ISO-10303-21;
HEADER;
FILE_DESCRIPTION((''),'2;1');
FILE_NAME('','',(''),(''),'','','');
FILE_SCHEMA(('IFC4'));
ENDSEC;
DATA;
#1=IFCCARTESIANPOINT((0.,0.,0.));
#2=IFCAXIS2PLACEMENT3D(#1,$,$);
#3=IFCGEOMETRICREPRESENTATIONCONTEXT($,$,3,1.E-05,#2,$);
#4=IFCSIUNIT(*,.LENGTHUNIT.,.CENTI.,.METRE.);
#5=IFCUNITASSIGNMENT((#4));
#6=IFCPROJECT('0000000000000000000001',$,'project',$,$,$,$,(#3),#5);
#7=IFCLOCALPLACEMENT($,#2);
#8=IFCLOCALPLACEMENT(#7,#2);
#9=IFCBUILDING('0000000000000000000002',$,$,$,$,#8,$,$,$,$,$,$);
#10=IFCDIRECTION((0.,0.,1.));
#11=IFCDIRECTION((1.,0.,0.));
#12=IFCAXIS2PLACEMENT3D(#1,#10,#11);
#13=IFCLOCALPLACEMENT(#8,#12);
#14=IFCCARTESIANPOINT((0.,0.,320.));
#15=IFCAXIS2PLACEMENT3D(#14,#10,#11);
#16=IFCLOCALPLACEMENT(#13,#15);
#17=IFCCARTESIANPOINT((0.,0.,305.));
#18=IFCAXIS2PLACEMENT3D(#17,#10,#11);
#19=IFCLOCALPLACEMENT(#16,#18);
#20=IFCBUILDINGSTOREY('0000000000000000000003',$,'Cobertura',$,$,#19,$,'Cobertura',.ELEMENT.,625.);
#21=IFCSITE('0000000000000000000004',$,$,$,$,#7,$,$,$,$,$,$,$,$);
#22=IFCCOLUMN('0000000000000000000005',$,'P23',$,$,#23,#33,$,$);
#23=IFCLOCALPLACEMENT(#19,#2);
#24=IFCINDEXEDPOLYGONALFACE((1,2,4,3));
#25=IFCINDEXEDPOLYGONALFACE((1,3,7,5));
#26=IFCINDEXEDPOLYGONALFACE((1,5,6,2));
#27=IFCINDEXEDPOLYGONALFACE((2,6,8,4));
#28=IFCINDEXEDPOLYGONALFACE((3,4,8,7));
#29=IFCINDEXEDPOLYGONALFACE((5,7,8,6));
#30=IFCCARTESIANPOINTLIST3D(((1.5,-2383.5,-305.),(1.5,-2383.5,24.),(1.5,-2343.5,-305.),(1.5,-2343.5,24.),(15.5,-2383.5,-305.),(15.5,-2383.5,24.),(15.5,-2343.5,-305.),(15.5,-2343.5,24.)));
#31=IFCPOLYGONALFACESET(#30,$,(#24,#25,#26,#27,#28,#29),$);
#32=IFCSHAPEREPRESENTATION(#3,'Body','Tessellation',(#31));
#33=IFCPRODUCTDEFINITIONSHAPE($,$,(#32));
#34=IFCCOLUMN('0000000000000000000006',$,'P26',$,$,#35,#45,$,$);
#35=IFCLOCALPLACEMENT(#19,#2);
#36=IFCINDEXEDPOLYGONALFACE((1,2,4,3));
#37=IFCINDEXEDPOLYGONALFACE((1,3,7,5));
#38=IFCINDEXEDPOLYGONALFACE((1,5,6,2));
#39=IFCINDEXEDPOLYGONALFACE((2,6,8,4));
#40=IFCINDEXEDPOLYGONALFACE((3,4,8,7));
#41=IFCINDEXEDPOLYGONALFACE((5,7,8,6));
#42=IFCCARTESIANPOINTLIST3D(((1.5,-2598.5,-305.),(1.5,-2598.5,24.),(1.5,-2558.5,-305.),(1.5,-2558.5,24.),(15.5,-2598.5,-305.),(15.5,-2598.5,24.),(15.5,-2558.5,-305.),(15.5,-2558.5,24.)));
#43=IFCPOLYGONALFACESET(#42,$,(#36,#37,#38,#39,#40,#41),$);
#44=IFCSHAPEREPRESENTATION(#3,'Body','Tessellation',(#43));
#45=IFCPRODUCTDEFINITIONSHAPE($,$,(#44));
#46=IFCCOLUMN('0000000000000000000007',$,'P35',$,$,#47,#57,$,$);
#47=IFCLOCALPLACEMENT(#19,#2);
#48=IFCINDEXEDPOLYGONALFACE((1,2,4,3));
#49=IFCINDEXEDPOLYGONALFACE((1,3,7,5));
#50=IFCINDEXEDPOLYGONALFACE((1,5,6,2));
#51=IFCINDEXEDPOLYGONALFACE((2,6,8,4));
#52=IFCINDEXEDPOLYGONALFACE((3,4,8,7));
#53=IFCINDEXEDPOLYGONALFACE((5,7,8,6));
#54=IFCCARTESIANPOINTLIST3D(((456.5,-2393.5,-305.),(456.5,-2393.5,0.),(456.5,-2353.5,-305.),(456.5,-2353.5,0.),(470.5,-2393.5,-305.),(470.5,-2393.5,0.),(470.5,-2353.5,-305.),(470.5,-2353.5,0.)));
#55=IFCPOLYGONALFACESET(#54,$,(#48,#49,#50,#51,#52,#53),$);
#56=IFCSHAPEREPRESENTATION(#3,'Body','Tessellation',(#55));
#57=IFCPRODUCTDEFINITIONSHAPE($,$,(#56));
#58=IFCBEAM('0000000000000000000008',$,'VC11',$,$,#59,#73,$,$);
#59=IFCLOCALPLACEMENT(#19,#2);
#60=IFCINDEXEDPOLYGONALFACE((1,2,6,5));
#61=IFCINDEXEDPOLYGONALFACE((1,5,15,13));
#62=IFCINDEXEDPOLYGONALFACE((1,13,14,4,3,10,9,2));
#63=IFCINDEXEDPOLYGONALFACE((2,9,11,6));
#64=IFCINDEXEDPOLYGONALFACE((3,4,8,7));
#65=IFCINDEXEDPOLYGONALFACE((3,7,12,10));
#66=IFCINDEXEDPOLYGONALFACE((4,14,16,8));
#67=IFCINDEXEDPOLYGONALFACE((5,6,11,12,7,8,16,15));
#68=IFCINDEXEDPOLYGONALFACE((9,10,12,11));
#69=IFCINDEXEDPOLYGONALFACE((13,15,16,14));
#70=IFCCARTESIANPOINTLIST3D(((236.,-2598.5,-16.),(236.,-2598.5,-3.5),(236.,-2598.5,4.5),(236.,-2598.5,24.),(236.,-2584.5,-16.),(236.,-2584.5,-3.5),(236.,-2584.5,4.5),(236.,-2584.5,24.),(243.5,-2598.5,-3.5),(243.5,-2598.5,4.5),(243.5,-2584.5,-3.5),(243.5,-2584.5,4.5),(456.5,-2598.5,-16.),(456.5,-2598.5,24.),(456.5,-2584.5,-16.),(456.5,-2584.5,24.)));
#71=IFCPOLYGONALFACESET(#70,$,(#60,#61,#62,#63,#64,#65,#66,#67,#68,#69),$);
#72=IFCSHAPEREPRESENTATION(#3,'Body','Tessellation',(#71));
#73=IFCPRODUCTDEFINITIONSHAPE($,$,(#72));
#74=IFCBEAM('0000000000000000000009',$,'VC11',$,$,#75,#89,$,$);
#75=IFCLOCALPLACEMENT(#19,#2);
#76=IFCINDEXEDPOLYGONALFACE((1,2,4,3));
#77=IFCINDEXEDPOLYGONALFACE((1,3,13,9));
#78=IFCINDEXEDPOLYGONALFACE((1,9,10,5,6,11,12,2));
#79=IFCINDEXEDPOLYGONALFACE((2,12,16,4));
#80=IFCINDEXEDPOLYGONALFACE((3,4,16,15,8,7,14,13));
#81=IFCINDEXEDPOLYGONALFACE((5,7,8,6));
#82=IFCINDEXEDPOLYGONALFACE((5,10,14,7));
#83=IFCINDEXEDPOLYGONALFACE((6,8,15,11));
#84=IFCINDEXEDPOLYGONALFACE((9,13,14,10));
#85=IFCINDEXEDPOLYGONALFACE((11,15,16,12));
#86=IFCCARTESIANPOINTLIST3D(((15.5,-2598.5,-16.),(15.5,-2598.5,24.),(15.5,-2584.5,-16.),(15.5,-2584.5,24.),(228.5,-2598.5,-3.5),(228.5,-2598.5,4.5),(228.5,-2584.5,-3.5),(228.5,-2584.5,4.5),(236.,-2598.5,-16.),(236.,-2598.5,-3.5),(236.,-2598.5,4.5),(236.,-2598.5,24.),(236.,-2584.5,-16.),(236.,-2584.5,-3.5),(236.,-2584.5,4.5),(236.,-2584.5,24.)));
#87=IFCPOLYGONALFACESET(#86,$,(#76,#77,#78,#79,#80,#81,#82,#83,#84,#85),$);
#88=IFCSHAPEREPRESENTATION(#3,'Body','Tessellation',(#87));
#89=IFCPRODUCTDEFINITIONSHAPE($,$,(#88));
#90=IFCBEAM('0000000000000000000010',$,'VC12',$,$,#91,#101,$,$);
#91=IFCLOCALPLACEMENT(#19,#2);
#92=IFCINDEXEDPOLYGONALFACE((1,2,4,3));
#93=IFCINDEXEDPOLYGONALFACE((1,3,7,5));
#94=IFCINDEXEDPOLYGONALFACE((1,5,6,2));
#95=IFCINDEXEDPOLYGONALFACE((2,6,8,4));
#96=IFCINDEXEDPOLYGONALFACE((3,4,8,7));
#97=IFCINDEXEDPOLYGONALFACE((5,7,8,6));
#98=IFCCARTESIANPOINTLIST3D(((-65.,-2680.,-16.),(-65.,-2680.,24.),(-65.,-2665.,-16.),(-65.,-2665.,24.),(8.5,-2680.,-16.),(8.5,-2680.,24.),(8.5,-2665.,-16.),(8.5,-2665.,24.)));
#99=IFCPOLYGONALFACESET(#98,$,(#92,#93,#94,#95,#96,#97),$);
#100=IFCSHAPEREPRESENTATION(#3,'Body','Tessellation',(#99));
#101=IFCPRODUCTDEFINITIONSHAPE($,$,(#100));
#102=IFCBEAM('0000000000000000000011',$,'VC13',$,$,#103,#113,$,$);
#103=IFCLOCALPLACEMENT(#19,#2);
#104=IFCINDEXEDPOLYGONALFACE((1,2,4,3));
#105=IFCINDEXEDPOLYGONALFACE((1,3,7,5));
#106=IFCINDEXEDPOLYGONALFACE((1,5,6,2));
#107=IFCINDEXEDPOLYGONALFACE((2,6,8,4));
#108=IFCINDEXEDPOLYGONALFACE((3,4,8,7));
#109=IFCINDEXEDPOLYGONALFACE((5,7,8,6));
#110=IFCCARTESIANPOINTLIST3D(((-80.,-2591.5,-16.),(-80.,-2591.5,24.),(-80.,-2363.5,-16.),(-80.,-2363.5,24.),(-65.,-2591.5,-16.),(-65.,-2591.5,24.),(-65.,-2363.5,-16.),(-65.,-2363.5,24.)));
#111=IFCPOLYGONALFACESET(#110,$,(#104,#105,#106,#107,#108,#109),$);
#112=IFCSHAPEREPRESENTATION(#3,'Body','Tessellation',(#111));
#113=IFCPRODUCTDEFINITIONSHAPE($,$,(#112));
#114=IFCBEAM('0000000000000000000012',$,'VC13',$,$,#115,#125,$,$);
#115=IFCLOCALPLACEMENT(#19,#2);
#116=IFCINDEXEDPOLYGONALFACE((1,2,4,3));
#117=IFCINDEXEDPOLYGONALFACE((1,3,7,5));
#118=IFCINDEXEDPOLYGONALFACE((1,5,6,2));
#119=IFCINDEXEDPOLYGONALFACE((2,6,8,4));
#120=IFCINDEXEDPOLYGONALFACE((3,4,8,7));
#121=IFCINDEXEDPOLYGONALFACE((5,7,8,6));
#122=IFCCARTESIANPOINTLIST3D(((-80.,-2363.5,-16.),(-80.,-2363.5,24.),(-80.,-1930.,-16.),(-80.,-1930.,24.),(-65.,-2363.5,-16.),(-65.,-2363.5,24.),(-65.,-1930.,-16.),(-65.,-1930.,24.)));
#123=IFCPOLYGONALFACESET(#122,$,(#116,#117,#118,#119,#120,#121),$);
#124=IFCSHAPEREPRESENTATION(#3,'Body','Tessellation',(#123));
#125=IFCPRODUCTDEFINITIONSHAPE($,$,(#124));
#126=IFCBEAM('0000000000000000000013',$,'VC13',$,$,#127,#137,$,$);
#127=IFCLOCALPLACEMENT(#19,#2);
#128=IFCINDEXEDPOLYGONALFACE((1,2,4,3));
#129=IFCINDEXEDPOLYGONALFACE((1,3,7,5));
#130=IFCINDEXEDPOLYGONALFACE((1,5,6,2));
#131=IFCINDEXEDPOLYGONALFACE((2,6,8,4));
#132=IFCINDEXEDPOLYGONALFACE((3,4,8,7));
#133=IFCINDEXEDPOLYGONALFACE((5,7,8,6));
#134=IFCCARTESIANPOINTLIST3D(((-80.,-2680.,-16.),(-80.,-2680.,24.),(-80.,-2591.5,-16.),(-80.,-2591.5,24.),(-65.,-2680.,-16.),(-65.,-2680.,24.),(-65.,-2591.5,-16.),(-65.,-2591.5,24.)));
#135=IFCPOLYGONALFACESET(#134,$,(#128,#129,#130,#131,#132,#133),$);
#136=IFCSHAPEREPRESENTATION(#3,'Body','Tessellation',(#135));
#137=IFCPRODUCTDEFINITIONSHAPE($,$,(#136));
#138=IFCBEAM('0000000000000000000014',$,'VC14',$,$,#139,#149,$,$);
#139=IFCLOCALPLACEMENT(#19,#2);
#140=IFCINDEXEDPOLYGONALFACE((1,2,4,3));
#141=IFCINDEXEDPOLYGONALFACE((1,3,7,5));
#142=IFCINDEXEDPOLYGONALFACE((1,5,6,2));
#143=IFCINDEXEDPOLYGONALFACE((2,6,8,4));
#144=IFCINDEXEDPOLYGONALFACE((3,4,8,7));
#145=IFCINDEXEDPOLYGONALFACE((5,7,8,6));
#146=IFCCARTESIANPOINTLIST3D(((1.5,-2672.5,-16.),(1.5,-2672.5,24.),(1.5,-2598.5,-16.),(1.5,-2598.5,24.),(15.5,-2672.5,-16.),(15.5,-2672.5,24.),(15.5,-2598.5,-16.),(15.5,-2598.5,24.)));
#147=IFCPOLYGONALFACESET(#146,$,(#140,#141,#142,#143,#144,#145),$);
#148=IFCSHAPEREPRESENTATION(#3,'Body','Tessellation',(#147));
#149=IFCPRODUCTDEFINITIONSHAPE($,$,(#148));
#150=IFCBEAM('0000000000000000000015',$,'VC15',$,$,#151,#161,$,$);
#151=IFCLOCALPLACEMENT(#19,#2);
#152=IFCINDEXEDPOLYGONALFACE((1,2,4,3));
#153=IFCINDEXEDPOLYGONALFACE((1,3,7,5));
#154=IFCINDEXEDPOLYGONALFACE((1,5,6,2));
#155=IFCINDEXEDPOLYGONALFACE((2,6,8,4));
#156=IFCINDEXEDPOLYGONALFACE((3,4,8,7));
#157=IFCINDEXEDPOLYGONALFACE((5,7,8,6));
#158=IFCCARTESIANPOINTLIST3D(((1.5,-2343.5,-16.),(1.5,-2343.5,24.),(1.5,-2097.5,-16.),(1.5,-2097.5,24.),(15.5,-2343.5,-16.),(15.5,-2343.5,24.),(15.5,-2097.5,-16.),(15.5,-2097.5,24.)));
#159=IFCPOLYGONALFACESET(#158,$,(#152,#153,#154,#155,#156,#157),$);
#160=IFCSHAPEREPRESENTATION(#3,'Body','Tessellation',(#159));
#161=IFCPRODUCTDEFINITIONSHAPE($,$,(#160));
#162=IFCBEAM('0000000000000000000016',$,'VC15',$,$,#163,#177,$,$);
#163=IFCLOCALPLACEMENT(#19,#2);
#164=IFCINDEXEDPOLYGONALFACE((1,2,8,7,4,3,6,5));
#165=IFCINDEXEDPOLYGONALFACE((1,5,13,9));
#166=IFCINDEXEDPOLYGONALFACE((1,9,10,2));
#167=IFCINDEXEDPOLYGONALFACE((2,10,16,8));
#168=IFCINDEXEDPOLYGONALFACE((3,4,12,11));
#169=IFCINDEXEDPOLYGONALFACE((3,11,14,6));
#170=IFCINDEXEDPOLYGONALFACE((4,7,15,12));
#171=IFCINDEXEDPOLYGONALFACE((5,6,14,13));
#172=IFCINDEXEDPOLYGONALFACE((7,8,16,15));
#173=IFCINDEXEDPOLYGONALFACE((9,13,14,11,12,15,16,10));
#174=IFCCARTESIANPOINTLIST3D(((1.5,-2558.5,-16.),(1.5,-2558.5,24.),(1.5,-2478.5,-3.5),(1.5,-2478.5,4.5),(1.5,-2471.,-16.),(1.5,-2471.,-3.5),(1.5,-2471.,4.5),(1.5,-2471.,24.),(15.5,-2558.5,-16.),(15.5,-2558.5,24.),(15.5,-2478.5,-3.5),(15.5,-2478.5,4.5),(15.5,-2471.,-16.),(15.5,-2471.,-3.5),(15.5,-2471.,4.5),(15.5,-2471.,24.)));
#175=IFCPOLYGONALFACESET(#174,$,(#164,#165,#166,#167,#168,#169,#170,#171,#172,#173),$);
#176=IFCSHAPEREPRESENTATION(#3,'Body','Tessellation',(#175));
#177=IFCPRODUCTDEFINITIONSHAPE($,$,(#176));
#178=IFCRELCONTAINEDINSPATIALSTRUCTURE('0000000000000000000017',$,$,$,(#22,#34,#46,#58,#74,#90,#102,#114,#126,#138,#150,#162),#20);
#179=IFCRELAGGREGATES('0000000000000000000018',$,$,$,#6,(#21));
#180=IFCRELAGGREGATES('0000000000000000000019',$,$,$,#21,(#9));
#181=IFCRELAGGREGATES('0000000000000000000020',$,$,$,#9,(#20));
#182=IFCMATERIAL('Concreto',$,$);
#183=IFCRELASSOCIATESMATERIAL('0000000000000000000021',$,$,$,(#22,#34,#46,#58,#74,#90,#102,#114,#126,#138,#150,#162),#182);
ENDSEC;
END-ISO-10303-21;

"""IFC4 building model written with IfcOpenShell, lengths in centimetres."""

from ifc_helpers import new_model, si_unit, frame, origin, origin_with_axes, place, context, project, spatial, polyline, outline, extrude, material, element, save


model = new_model("IFC4")

# Units and contexts
context_of_model = context(None, 3, precision=1e-05, world=origin())
ifc_project = project(units=[si_unit("LENGTHUNIT", "METRE", prefix="CENTI")], contexts=[context_of_model])

# Site, building, storey
site_placement = place(None, origin())
site = spatial("IfcSite", under=ifc_project, at=site_placement)
building_placement = place(site_placement, origin())
building = spatial("IfcBuilding", under=site, at=building_placement)
placement_1 = place(building_placement, origin_with_axes())
placement_2 = place(placement_1, frame((0.0, 0.0, 320.0), z_axis=(0.0, 0.0, 1.0), x_axis=(1.0, 0.0, 0.0)))
storey_placement = place(placement_2, frame((0.0, 0.0, 305.0), z_axis=(0.0, 0.0, 1.0), x_axis=(1.0, 0.0, 0.0)))
storey = spatial("IfcBuildingStorey", under=building, at=storey_placement, Name="Cobertura", LongName="Cobertura", CompositionType="ELEMENT", Elevation=625.0)

# Columns
ifc_material = material(Name="Concreto")
for number, where, z_axis, x_axis, name in (
    (1, (8.5, -2363.5, 24.0), (0.0, 0.0, 1.0), (1.0, 0.0, 0.0), "P23"),
    (2, (8.5, -2578.5, 24.0), (0.0, 0.0, 1.0), (1.0, 0.0, 0.0), "P26"),
):
    element("IfcColumn", number, at=place(storey_placement, frame(where, z_axis=z_axis, x_axis=x_axis)), inside=storey, material=ifc_material, Name=name, context=context_of_model, shape_type="SolidModel", body=[
        extrude(outline(polyline([(-7.0, -20.0), (7.0, -20.0), (7.0, 20.0), (-7.0, 20.0), (-7.0, -20.0)])), frame((0.0, 0.0, 0.0), z_axis=(0.0, 0.0, 1.0), x_axis=(1.0, 0.0, 0.0)), (0.0, 0.0, -1.0), 329.0),
    ])
column_placement = place(storey_placement, frame((463.5, -2373.5, 0.0), z_axis=(0.0, 0.0, 1.0), x_axis=(1.0, 0.0, 0.0)))
element("IfcColumn", 3, at=column_placement, inside=storey, material=ifc_material, Name="P35", context=context_of_model, shape_type="SolidModel", body=[
    extrude(outline(polyline([(-7.0, -20.0), (7.0, -20.0), (7.0, 20.0), (-7.0, 20.0), (-7.0, -20.0)])), origin_with_axes(), (0.0, 0.0, -1.0), 305.0),
])

# Beams, openings
beam_1_placement = place(storey_placement, frame((346.25, -2591.5, 24.0), z_axis=(0.0, 0.0, 1.0), x_axis=(1.0, 0.0, 0.0)))
beam_1 = element("IfcBeam", 4, at=beam_1_placement, inside=storey, material=ifc_material, Name="VC11", context=context_of_model, shape_type="SolidModel", body=[
    extrude(outline(polyline([(-7.0, -20.0), (7.0, -20.0), (7.0, 20.0), (-7.0, 20.0), (-7.0, -20.0)])), frame((-110.25, 0.0, -20.0), z_axis=(1.0, 0.0, 0.0), x_axis=(0.0, -1.0, 0.0)), (0.0, 0.0, 1.0), 220.5),
])
opening_1_placement = place(storey_placement, frame((0.0, 0.0, -625.0), z_axis=(0.0, 0.0, 1.0), x_axis=(1.0, 0.0, 0.0)))
element("IfcOpeningElement", 5, at=opening_1_placement, cuts=beam_1, material=ifc_material, context=context_of_model, shape_type="SweptSolid", body=[
    extrude(outline(polyline([(7.5, 4.0), (-7.5, 4.0), (-7.5, -4.0), (7.5, -4.0), (7.5, 4.0)])), frame((236.0, -2598.5, 625.5), z_axis=(0.0, 1.0, 0.0), x_axis=(-1.0, 0.0, 0.0)), (0.0, 0.0, 1.0), 14.0),
])
beam_2_placement = place(storey_placement, frame((125.75, -2591.5, 24.0), z_axis=(0.0, 0.0, 1.0), x_axis=(1.0, 0.0, 0.0)))
beam_2 = element("IfcBeam", 6, at=beam_2_placement, inside=storey, material=ifc_material, Name="VC11", context=context_of_model, shape_type="SolidModel", body=[
    extrude(outline(polyline([(-7.0, -20.0), (7.0, -20.0), (7.0, 20.0), (-7.0, 20.0), (-7.0, -20.0)])), frame((-110.25, 0.0, -20.0), z_axis=(1.0, 0.0, 0.0), x_axis=(0.0, -1.0, 0.0)), (0.0, 0.0, 1.0), 220.5),
])
opening_2_placement = place(storey_placement, frame((0.0, 0.0, -625.0), z_axis=(0.0, 0.0, 1.0), x_axis=(1.0, 0.0, 0.0)))
element("IfcOpeningElement", 7, at=opening_2_placement, cuts=beam_2, material=ifc_material, context=context_of_model, shape_type="SweptSolid", body=[
    extrude(outline(polyline([(7.5, 4.0), (-7.5, 4.0), (-7.5, -4.0), (7.5, -4.0), (7.5, 4.0)])), frame((236.0, -2598.5, 625.5), z_axis=(0.0, 1.0, 0.0), x_axis=(-1.0, 0.0, 0.0)), (0.0, 0.0, 1.0), 14.0),
])

# Beams
beam_3_placement = place(storey_placement, frame((-28.25, -2672.5, 24.0), z_axis=(0.0, 0.0, 1.0), x_axis=(1.0, 0.0, 0.0)))
element("IfcBeam", 8, at=beam_3_placement, inside=storey, material=ifc_material, Name="VC12", context=context_of_model, shape_type="SolidModel", body=[
    extrude(outline(polyline([(-7.5, -20.0), (7.5, -20.0), (7.5, 20.0), (-7.5, 20.0), (-7.5, -20.0)])), frame((-36.75, 0.0, -20.0), z_axis=(1.0, 0.0, 0.0), x_axis=(0.0, -1.0, 0.0)), (0.0, 0.0, 1.0), 73.5),
])
beam_4_placement = place(storey_placement, frame((-72.5, -2477.5, 24.0), z_axis=(0.0, 0.0, 1.0), x_axis=(1.0, 0.0, 0.0)))
element("IfcBeam", 9, at=beam_4_placement, inside=storey, material=ifc_material, Name="VC13", context=context_of_model, shape_type="SolidModel", body=[
    extrude(outline(polyline([(-7.5, -20.0), (7.5, -20.0), (7.5, 20.0), (-7.5, 20.0), (-7.5, -20.0)])), frame((0.0, -114.0, -20.0), z_axis=(0.0, 1.0, 0.0), x_axis=(1.0, 0.0, 0.0)), (0.0, 0.0, 1.0), 228.0),
])
beam_5_placement = place(storey_placement, frame((-72.5, -2146.75, 24.0), z_axis=(0.0, 0.0, 1.0), x_axis=(1.0, 0.0, 0.0)))
element("IfcBeam", 10, at=beam_5_placement, inside=storey, material=ifc_material, Name="VC13", context=context_of_model, shape_type="SolidModel", body=[
    extrude(outline(polyline([(-7.5, -20.0), (7.5, -20.0), (7.5, 20.0), (-7.5, 20.0), (-7.5, -20.0)])), frame((0.0, -216.75, -20.0), z_axis=(0.0, 1.0, 0.0), x_axis=(1.0, 0.0, 0.0)), (0.0, 0.0, 1.0), 433.5),
])
beam_6_placement = place(storey_placement, frame((-72.5, -2635.75, 24.0), z_axis=(0.0, 0.0, 1.0), x_axis=(1.0, 0.0, 0.0)))
element("IfcBeam", 11, at=beam_6_placement, inside=storey, material=ifc_material, Name="VC13", context=context_of_model, shape_type="SolidModel", body=[
    extrude(outline(polyline([(-7.5, -20.0), (7.5, -20.0), (7.5, 20.0), (-7.5, 20.0), (-7.5, -20.0)])), frame((0.0, -44.25, -20.0), z_axis=(0.0, 1.0, 0.0), x_axis=(1.0, 0.0, 0.0)), (0.0, 0.0, 1.0), 88.5),
])
beam_7_placement = place(storey_placement, frame((8.5, -2635.5, 24.0), z_axis=(0.0, 0.0, 1.0), x_axis=(1.0, 0.0, 0.0)))
element("IfcBeam", 12, at=beam_7_placement, inside=storey, material=ifc_material, Name="VC14", context=context_of_model, shape_type="SolidModel", body=[
    extrude(outline(polyline([(-7.0, -20.0), (7.0, -20.0), (7.0, 20.0), (-7.0, 20.0), (-7.0, -20.0)])), frame((0.0, -37.0, -20.0), z_axis=(0.0, 1.0, 0.0), x_axis=(1.0, 0.0, 0.0)), (0.0, 0.0, 1.0), 74.0),
])
beam_8_placement = place(storey_placement, frame((8.5, -2220.5, 24.0), z_axis=(0.0, 0.0, 1.0), x_axis=(1.0, 0.0, 0.0)))
element("IfcBeam", 13, at=beam_8_placement, inside=storey, material=ifc_material, Name="VC15", context=context_of_model, shape_type="SolidModel", body=[
    extrude(outline(polyline([(-7.0, -20.0), (7.0, -20.0), (7.0, 20.0), (-7.0, 20.0), (-7.0, -20.0)])), frame((0.0, -123.0, -20.0), z_axis=(0.0, 1.0, 0.0), x_axis=(1.0, 0.0, 0.0)), (0.0, 0.0, 1.0), 246.0),
])

# Beam, opening
beam_9_placement = place(storey_placement, frame((8.5, -2514.75, 24.0), z_axis=(0.0, 0.0, 1.0), x_axis=(1.0, 0.0, 0.0)))
beam_9 = element("IfcBeam", 14, at=beam_9_placement, inside=storey, material=ifc_material, Name="VC15", context=context_of_model, shape_type="SolidModel", body=[
    extrude(outline(polyline([(-7.0, -20.0), (7.0, -20.0), (7.0, 20.0), (-7.0, 20.0), (-7.0, -20.0)])), frame((0.0, -43.75, -20.0), z_axis=(0.0, 1.0, 0.0), x_axis=(1.0, 0.0, 0.0)), (0.0, 0.0, 1.0), 87.5),
])
opening_3_placement = place(storey_placement, frame((0.0, 0.0, -625.0), z_axis=(0.0, 0.0, 1.0), x_axis=(1.0, 0.0, 0.0)))
element("IfcOpeningElement", 15, at=opening_3_placement, cuts=beam_9, material=ifc_material, context=context_of_model, shape_type="SweptSolid", body=[
    extrude(outline(polyline([(7.5, 4.0), (-7.5, 4.0), (-7.5, -4.0), (7.5, -4.0), (7.5, 4.0)])), frame((15.5, -2471.0, 625.5), z_axis=(-1.0, 0.0, 0.0), x_axis=(0.0, -1.0, 0.0)), (0.0, 0.0, 1.0), 14.0),
])

save(model, "model.ifc")
